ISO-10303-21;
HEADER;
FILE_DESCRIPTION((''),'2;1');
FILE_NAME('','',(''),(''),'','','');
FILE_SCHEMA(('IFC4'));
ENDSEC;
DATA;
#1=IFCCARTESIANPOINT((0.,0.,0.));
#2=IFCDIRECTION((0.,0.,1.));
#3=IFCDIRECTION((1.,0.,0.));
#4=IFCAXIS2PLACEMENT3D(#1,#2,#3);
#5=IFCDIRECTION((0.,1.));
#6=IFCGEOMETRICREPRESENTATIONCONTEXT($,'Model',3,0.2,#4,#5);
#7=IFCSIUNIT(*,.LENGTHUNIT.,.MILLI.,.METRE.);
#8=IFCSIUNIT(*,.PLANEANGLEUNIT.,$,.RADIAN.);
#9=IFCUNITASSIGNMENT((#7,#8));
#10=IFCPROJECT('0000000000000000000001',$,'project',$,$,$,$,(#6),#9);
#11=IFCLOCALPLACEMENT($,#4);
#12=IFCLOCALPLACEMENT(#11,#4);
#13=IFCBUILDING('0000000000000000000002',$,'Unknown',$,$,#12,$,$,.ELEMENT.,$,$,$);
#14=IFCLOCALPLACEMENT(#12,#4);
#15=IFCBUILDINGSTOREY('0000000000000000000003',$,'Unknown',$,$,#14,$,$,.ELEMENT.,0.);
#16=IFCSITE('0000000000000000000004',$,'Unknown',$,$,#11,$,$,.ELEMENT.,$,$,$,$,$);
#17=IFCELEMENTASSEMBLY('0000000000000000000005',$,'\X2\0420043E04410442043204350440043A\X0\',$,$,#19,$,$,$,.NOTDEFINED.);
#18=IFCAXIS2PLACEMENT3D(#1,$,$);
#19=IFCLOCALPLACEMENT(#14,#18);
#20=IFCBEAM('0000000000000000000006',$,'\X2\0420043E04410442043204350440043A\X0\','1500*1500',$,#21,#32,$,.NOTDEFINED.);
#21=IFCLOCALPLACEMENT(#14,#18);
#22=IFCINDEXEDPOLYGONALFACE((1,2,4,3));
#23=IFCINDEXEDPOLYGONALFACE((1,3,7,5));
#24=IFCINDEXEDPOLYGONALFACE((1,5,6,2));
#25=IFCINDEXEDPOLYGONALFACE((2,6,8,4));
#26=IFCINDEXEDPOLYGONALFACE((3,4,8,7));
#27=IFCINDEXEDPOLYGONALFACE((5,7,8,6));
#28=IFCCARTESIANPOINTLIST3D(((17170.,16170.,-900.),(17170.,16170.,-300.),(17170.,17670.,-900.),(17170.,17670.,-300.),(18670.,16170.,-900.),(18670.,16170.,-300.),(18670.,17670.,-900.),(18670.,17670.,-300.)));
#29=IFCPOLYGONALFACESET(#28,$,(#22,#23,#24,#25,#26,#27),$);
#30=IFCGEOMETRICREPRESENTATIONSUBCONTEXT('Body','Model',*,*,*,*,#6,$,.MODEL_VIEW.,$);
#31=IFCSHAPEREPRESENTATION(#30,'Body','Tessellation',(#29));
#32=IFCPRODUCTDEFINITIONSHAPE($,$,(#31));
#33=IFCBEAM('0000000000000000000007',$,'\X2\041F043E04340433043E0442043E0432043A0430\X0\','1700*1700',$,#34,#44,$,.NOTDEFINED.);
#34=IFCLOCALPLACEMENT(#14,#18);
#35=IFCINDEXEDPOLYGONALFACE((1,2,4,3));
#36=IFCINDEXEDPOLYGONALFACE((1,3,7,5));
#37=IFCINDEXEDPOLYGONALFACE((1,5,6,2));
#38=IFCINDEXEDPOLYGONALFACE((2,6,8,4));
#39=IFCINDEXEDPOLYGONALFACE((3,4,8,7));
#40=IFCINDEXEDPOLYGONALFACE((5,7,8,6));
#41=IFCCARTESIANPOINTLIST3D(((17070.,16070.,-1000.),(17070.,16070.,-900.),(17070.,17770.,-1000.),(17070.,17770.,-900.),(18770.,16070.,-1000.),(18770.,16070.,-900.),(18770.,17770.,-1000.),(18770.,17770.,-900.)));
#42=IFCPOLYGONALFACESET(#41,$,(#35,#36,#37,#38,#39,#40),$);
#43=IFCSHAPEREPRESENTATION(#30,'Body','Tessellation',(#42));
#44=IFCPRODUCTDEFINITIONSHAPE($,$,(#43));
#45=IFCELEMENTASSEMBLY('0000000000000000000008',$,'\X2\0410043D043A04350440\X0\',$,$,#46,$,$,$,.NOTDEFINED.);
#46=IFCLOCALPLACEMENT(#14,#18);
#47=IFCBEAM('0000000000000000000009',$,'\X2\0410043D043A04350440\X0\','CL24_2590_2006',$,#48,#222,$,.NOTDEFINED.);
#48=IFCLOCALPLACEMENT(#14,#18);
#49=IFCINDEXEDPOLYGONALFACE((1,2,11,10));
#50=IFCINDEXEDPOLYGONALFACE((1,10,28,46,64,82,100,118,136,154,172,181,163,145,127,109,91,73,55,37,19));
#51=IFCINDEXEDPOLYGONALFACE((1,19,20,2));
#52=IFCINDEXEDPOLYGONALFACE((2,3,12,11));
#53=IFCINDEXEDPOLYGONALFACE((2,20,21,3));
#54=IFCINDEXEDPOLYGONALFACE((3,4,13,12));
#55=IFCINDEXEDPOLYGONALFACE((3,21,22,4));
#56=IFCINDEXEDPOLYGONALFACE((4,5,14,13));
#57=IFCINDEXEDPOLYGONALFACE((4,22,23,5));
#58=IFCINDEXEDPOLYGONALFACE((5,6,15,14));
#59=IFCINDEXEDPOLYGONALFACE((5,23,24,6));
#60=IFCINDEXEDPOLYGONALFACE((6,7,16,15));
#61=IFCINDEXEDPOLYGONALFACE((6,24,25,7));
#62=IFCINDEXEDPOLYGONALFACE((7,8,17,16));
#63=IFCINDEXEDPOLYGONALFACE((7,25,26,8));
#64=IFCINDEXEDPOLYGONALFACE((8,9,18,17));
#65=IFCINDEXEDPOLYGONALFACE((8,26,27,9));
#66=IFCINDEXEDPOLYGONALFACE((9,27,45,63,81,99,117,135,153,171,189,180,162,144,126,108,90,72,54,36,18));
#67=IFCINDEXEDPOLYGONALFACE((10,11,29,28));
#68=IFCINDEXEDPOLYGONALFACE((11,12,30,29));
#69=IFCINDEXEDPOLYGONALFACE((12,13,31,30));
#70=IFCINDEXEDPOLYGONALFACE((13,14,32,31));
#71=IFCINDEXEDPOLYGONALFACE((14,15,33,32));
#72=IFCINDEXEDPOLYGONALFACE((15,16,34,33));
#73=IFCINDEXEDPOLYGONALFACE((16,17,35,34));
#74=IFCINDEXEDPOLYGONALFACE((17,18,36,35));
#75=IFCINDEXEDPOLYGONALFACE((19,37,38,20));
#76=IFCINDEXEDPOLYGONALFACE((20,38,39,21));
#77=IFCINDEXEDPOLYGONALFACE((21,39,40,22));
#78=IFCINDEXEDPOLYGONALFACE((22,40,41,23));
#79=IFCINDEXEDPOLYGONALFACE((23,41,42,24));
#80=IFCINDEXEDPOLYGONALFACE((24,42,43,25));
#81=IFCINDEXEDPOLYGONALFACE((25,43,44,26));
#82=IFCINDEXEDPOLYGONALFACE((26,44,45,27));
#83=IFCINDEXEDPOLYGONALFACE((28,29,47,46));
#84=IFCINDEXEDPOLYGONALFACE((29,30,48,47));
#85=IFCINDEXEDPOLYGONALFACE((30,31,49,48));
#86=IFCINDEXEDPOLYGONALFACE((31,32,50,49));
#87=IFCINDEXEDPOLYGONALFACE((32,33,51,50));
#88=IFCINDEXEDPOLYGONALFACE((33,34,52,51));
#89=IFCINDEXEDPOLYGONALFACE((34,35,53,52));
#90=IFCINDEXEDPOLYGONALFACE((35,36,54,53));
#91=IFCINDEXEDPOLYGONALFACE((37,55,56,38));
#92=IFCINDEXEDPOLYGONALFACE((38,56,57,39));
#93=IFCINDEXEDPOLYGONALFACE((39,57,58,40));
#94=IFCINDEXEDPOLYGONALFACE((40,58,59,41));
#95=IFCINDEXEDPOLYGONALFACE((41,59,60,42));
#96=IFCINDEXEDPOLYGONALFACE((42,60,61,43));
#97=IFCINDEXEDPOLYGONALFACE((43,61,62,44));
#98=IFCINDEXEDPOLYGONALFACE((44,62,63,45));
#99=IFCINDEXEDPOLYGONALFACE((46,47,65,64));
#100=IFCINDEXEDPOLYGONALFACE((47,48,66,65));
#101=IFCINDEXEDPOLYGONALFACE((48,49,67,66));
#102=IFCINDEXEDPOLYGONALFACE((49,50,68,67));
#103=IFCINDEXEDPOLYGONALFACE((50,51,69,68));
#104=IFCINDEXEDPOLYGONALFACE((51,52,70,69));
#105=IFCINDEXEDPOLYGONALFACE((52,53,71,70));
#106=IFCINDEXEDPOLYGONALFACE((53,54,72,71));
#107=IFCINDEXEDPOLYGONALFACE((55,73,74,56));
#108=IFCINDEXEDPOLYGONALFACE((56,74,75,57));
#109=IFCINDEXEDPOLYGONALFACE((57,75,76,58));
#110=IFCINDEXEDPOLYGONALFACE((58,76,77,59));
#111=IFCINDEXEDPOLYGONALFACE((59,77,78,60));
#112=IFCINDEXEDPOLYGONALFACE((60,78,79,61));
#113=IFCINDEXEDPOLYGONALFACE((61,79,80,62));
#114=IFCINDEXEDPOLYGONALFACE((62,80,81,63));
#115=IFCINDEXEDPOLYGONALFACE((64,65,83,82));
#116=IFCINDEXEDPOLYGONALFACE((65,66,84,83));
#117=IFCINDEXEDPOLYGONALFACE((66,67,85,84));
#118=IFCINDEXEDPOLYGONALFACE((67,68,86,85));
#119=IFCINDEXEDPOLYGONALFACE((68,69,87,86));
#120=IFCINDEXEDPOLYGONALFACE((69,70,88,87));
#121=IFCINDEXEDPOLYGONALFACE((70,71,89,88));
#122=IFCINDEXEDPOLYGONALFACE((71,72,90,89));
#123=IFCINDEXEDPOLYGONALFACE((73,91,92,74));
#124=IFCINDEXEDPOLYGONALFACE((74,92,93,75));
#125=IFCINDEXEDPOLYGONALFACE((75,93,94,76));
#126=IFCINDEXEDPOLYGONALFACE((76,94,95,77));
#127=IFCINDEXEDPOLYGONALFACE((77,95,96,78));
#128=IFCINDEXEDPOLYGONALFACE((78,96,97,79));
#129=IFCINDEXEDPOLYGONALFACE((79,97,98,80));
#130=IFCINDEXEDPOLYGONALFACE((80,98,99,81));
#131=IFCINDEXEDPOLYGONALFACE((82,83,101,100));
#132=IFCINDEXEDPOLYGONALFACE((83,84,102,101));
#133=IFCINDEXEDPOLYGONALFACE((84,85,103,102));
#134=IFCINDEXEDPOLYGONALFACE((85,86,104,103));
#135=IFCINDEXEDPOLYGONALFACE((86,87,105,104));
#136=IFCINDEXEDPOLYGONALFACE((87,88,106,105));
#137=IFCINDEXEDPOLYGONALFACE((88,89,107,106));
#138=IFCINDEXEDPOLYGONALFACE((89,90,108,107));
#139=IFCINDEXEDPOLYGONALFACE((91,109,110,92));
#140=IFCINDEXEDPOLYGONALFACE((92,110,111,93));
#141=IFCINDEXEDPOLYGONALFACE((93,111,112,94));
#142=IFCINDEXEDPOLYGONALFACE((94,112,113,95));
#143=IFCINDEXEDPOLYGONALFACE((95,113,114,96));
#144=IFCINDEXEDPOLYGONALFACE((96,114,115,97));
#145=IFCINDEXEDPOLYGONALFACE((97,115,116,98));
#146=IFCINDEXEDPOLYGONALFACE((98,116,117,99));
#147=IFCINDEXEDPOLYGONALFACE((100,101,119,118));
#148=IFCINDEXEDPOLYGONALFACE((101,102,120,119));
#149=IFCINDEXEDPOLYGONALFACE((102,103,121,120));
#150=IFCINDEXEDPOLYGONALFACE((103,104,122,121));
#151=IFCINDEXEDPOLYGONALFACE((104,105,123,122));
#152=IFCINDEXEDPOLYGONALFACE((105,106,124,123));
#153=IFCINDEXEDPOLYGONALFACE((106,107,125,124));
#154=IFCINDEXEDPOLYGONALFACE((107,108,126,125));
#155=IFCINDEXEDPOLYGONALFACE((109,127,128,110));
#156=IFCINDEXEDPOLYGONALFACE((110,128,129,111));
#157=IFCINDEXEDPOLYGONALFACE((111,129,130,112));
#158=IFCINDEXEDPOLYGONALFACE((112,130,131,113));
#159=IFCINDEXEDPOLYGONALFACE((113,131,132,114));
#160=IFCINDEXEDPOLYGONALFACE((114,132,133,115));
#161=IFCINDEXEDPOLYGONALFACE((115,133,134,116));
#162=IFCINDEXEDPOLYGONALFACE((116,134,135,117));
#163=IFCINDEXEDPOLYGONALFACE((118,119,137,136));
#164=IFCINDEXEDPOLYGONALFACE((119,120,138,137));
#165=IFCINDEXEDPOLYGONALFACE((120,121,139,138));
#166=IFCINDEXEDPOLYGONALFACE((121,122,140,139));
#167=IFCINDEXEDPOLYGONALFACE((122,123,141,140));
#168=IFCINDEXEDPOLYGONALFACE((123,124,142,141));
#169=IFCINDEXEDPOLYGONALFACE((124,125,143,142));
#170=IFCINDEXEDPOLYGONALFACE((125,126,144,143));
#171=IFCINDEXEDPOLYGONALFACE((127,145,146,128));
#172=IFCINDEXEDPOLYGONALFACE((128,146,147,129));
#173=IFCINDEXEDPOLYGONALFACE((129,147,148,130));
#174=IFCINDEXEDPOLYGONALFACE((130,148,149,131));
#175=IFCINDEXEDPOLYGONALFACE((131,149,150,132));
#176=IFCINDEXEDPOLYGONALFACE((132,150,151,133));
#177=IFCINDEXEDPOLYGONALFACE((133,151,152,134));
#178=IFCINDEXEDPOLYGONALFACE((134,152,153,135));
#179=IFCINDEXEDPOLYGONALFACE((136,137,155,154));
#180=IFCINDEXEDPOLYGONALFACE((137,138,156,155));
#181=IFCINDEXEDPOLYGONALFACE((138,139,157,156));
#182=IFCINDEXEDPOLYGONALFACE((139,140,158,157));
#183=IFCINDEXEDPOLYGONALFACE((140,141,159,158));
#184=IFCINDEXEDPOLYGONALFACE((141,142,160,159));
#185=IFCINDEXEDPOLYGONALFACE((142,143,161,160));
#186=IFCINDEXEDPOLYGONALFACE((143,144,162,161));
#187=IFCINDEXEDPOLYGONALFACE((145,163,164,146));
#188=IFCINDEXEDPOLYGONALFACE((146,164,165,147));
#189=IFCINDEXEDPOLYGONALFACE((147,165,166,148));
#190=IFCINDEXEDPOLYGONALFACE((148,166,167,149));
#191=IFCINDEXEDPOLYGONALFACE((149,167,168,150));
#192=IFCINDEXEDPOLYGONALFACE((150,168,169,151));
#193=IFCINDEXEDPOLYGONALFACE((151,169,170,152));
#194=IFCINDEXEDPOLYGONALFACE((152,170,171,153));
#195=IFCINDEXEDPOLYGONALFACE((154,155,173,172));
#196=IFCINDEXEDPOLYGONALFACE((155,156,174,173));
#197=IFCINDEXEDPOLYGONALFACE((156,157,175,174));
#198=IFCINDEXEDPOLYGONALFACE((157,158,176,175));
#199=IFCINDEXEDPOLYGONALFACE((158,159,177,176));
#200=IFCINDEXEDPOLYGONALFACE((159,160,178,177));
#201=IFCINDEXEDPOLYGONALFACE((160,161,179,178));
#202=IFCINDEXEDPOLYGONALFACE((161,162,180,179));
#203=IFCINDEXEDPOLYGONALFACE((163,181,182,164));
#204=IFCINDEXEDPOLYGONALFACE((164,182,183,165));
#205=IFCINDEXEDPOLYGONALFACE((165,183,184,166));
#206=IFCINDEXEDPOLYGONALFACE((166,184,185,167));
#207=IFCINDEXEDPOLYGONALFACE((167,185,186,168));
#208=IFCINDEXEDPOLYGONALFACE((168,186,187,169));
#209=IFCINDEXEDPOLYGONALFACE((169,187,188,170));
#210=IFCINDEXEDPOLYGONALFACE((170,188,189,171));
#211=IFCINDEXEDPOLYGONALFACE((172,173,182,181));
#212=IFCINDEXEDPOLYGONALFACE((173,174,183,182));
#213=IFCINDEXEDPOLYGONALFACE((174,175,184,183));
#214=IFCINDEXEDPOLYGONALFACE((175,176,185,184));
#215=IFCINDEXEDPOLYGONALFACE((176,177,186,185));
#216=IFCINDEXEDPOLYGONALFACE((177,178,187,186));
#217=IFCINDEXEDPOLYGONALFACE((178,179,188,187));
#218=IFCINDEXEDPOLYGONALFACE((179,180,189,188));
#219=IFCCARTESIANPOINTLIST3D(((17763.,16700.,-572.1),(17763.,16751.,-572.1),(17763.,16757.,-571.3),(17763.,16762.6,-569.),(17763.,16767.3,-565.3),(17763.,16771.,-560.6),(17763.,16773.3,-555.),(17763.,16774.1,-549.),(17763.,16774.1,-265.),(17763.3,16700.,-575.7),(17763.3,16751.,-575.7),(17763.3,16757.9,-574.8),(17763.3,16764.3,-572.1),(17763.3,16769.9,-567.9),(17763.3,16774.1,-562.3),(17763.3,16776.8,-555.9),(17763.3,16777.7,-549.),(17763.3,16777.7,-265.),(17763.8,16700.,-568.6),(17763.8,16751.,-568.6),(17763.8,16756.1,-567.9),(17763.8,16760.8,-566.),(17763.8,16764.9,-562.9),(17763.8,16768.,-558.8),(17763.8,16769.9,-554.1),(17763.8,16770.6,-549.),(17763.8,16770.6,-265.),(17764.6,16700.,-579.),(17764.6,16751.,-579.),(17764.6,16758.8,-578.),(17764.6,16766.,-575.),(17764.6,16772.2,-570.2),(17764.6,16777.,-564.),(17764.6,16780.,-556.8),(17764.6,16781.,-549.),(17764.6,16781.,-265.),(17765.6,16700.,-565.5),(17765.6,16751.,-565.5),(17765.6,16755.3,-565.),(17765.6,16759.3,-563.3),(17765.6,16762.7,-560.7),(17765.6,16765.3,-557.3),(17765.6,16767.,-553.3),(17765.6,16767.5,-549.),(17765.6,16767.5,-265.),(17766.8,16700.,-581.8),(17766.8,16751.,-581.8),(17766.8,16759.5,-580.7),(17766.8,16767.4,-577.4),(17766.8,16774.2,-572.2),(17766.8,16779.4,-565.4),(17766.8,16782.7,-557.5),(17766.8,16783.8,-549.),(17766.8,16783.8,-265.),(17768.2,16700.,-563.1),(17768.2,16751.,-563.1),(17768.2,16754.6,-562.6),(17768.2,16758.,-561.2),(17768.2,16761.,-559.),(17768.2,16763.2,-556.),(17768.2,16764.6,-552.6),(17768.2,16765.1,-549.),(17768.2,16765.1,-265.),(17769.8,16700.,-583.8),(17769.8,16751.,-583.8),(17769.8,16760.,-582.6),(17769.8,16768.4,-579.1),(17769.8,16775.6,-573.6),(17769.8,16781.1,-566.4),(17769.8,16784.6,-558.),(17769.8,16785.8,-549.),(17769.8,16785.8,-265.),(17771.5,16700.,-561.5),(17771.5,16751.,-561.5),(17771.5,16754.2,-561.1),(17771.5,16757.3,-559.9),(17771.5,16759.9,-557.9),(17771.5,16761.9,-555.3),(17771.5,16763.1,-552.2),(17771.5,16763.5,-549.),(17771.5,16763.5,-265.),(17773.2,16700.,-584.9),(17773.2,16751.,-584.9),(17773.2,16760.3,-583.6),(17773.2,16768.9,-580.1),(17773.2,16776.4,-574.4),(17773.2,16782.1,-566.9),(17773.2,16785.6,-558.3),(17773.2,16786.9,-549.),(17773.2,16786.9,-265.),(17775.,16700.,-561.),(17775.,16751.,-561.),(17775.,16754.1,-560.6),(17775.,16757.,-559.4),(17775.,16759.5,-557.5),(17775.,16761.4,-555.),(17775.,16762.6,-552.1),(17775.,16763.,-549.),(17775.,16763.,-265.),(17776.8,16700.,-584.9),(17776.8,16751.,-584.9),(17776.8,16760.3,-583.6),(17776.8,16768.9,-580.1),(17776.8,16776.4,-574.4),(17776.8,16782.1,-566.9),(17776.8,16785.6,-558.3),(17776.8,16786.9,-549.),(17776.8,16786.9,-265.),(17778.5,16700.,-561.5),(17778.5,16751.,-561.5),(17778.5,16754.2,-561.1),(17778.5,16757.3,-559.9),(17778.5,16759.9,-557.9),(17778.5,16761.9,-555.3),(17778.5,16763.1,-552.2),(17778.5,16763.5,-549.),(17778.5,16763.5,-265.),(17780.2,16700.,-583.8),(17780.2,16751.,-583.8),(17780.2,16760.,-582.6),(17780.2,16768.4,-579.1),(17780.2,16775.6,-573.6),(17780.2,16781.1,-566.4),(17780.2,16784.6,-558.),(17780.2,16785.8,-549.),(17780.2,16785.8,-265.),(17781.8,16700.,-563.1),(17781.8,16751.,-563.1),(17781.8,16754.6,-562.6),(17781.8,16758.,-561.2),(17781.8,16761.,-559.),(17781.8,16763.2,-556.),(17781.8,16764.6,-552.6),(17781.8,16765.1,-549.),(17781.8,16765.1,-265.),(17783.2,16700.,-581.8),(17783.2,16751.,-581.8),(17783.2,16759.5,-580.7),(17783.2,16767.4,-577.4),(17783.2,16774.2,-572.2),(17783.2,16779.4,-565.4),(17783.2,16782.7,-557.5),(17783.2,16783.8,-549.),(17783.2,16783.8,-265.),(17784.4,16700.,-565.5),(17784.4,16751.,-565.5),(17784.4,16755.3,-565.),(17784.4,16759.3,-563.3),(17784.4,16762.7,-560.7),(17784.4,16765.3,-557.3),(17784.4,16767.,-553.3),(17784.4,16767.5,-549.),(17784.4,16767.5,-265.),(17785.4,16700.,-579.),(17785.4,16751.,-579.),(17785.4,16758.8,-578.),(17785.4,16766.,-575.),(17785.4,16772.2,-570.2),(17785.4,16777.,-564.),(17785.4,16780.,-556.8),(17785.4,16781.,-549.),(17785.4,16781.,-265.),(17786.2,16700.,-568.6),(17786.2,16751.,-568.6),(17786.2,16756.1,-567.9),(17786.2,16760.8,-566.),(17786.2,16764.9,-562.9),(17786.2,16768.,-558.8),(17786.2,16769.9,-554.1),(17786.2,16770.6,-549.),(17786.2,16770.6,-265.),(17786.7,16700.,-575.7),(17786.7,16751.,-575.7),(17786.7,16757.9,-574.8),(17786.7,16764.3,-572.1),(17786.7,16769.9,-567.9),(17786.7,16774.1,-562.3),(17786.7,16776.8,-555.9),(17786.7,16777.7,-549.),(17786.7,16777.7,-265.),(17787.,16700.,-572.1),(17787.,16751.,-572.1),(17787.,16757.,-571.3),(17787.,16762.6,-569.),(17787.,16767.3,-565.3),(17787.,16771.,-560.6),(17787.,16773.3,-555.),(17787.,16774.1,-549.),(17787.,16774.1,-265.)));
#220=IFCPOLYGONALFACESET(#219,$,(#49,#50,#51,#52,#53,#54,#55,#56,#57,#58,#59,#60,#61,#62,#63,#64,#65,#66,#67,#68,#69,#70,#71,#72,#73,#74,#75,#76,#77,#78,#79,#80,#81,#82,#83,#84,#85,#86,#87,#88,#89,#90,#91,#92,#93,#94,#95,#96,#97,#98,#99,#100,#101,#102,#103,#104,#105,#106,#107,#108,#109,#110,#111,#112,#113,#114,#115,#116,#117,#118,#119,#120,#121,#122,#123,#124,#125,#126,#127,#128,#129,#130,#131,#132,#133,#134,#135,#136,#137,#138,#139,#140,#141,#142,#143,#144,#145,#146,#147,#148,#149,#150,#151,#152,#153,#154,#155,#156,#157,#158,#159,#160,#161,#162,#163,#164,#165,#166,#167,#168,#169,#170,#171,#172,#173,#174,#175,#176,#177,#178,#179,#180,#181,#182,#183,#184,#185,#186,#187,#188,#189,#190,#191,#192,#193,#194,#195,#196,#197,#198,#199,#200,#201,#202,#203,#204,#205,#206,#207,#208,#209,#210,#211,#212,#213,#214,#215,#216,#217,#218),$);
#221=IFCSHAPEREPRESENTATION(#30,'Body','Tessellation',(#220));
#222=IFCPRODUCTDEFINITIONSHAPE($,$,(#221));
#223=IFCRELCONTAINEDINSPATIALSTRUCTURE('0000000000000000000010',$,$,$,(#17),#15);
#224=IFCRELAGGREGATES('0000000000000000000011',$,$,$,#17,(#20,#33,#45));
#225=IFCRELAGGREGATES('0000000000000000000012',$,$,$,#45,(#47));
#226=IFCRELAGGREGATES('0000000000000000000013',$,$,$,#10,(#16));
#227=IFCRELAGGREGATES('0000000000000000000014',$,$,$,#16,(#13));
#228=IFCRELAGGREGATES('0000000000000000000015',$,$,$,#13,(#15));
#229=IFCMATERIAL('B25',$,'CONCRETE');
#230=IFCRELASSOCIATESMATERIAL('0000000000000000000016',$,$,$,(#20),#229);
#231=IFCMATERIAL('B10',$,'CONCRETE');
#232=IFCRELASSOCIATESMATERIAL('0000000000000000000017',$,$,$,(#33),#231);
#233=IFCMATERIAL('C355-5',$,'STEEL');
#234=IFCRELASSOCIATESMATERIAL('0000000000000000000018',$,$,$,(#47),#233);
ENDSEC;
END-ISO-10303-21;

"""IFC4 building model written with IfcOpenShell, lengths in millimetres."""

from ifc_helpers import new_model, entity, si_unit, direction, frame, origin_with_axes, place, context, subcontext, project, spatial, line, indexed_curve, outline, extrude, material, element, aggregate, save


model = new_model("IFC4")

# Units and contexts
model_context = context("Model", 3, precision=0.2, world=origin_with_axes(), true_north=direction((0.0, 1.0)))
body_context = subcontext(model_context, "Body", "Model", "MODEL_VIEW")
ifc_project = project(units=[si_unit("LENGTHUNIT", "METRE", prefix="MILLI"), si_unit("PLANEANGLEUNIT", "RADIAN")], contexts=[model_context])

# Site, building, storey
site_placement = place(None, origin_with_axes())
site = spatial("IfcSite", under=ifc_project, at=site_placement, Name="Unknown", CompositionType="ELEMENT")
building_placement = place(site_placement, origin_with_axes())
building = spatial("IfcBuilding", under=site, at=building_placement, Name="Unknown", CompositionType="ELEMENT")
storey_placement = place(building_placement, origin_with_axes())
storey = spatial("IfcBuildingStorey", under=building, at=storey_placement, Name="Unknown", CompositionType="ELEMENT", Elevation=0.0)

# Element assemblies, beams, voiding feature
assembly_1_placement = place(storey_placement, frame((17920.0, 16920.0, -300.0), z_axis=(0.0, -1.0, 0.0), x_axis=(0.0, 0.0, -1.0)))
assembly_1 = element("IfcElementAssembly", 1, at=assembly_1_placement, inside=storey, Name="Ростверк", PredefinedType="NOTDEFINED")
ifc_material_1 = material(Name="B25", Category="CONCRETE")
beam_1_placement = place(assembly_1_placement, origin_with_axes())
beam_1 = element("IfcBeam", 2, at=beam_1_placement, material=ifc_material_1, Name="Ростверк", Description="1500*1500", PredefinedType="NOTDEFINED", context=body_context, shape_type="SolidModel", body=[
    extrude(outline(indexed_curve([(-750.0, -750.0), (750.0, -750.0), (750.0, 750.0), (-750.0, 750.0)], segments=[line(1, 2, 3, 4, 1)])), frame((0.0, 0.0, 0.0), z_axis=(-1.0, 0.0, 0.0), x_axis=(0.0, 0.0, 1.0)), (0.0, 0.0, -1.0), 600.0),
])
ifc_material_2 = material(Name="B10", Category="CONCRETE")
beam_2_placement = place(assembly_1_placement, frame((600.0, 0.0, 0.0), z_axis=(0.0, 0.0, 1.0), x_axis=(1.0, 0.0, 0.0)))
beam_2 = element("IfcBeam", 3, at=beam_2_placement, material=ifc_material_2, Name="Подготовка", Description="1700*1700", PredefinedType="NOTDEFINED", context=body_context, shape_type="SolidModel", body=[
    extrude(outline(indexed_curve([(-850.0, -850.0), (850.0, -850.0), (850.0, 850.0), (-850.0, 850.0)], segments=[line(1, 2, 3, 4, 1)])), frame((0.0, 0.0, 0.0), z_axis=(-1.0, 0.0, 0.0), x_axis=(0.0, 0.0, 1.0)), (0.0, 0.0, -1.0), 100.0),
])
assembly_2_placement = place(assembly_1_placement, frame((-215.0, -145.0, 145.0), z_axis=(0.0, 0.0, 1.0), x_axis=(1.0, 0.0, 0.0)))
assembly_2 = element("IfcElementAssembly", 4, at=assembly_2_placement, Name="Анкер", PredefinedType="NOTDEFINED")
aggregate(assembly_1, [beam_1, beam_2, assembly_2])
ifc_material_3 = material(Name="C355-5", Category="STEEL")
beam_3_placement = place(assembly_2_placement, origin_with_axes())
beam_3 = element("IfcBeam", 5, at=beam_3_placement, material=ifc_material_3, Name="Анкер", Description="CL24_2590_2006", PredefinedType="NOTDEFINED", context=body_context, shape_type="SolidModel", body=[
    entity("IfcSweptDiskSolid", entity("IfcIndexedPolyCurve", entity("IfcCartesianPointList3D", [[0.0, 0.0, 0.0], [464.0, 0.0, 0.0], [481.0, 0.0, 7.0], [488.0, 0.0, 24.0], [488.0, 0.0, 75.0]]), [entity("IfcLineIndex", [1, 2]), entity("IfcArcIndex", [2, 3, 4]), entity("IfcLineIndex", [4, 5])]), 12.0),
])
voiding_feature_1_placement = place(beam_3_placement, frame((0.0, 0.0, 0.0), z_axis=(0.0, -1.0, 0.0), x_axis=(1.0, 0.0, 0.0)))
element("IfcVoidingFeature", 6, at=voiding_feature_1_placement, cuts=beam_3, Name="Анкер", PredefinedType="HOLE", context=body_context, shape_type="SolidModel", body=[
    extrude(outline(indexed_curve([(12.5, 0.0), (12.2, 2.8), (11.3, 5.4), (9.8, 7.8), (7.8, 9.8), (5.4, 11.3), (2.8, 12.2), (0.0, 12.5), (-2.8, 12.2), (-5.4, 11.3), (-7.8, 9.8), (-9.8, 7.8), (-11.3, 5.4), (-12.2, 2.8), (-12.5, 0.0), (-12.2, -2.8), (-11.3, -5.4), (-9.8, -7.8), (-7.8, -9.8), (-5.4, -11.3), (-2.8, -12.2), (0.0, -12.5), (2.8, -12.2), (5.4, -11.3), (7.8, -9.8), (9.8, -7.8), (11.3, -5.4), (12.2, -2.8)], segments=[line(1, 2, 3, 4, 5, 6, 7, 8, 9, 10, 11, 12, 13, 14, 15, 16, 17, 18, 19, 20, 21, 22, 23, 24, 25, 26, 27, 28, 1)])), frame((0.0, 0.0, 0.0), z_axis=(-1.0, 0.0, 0.0), x_axis=(0.0, 0.0, 1.0)), (0.0, 0.0, -1.0), 180.0),
])
aggregate(assembly_2, [beam_3])

save(model, "model.ifc")
